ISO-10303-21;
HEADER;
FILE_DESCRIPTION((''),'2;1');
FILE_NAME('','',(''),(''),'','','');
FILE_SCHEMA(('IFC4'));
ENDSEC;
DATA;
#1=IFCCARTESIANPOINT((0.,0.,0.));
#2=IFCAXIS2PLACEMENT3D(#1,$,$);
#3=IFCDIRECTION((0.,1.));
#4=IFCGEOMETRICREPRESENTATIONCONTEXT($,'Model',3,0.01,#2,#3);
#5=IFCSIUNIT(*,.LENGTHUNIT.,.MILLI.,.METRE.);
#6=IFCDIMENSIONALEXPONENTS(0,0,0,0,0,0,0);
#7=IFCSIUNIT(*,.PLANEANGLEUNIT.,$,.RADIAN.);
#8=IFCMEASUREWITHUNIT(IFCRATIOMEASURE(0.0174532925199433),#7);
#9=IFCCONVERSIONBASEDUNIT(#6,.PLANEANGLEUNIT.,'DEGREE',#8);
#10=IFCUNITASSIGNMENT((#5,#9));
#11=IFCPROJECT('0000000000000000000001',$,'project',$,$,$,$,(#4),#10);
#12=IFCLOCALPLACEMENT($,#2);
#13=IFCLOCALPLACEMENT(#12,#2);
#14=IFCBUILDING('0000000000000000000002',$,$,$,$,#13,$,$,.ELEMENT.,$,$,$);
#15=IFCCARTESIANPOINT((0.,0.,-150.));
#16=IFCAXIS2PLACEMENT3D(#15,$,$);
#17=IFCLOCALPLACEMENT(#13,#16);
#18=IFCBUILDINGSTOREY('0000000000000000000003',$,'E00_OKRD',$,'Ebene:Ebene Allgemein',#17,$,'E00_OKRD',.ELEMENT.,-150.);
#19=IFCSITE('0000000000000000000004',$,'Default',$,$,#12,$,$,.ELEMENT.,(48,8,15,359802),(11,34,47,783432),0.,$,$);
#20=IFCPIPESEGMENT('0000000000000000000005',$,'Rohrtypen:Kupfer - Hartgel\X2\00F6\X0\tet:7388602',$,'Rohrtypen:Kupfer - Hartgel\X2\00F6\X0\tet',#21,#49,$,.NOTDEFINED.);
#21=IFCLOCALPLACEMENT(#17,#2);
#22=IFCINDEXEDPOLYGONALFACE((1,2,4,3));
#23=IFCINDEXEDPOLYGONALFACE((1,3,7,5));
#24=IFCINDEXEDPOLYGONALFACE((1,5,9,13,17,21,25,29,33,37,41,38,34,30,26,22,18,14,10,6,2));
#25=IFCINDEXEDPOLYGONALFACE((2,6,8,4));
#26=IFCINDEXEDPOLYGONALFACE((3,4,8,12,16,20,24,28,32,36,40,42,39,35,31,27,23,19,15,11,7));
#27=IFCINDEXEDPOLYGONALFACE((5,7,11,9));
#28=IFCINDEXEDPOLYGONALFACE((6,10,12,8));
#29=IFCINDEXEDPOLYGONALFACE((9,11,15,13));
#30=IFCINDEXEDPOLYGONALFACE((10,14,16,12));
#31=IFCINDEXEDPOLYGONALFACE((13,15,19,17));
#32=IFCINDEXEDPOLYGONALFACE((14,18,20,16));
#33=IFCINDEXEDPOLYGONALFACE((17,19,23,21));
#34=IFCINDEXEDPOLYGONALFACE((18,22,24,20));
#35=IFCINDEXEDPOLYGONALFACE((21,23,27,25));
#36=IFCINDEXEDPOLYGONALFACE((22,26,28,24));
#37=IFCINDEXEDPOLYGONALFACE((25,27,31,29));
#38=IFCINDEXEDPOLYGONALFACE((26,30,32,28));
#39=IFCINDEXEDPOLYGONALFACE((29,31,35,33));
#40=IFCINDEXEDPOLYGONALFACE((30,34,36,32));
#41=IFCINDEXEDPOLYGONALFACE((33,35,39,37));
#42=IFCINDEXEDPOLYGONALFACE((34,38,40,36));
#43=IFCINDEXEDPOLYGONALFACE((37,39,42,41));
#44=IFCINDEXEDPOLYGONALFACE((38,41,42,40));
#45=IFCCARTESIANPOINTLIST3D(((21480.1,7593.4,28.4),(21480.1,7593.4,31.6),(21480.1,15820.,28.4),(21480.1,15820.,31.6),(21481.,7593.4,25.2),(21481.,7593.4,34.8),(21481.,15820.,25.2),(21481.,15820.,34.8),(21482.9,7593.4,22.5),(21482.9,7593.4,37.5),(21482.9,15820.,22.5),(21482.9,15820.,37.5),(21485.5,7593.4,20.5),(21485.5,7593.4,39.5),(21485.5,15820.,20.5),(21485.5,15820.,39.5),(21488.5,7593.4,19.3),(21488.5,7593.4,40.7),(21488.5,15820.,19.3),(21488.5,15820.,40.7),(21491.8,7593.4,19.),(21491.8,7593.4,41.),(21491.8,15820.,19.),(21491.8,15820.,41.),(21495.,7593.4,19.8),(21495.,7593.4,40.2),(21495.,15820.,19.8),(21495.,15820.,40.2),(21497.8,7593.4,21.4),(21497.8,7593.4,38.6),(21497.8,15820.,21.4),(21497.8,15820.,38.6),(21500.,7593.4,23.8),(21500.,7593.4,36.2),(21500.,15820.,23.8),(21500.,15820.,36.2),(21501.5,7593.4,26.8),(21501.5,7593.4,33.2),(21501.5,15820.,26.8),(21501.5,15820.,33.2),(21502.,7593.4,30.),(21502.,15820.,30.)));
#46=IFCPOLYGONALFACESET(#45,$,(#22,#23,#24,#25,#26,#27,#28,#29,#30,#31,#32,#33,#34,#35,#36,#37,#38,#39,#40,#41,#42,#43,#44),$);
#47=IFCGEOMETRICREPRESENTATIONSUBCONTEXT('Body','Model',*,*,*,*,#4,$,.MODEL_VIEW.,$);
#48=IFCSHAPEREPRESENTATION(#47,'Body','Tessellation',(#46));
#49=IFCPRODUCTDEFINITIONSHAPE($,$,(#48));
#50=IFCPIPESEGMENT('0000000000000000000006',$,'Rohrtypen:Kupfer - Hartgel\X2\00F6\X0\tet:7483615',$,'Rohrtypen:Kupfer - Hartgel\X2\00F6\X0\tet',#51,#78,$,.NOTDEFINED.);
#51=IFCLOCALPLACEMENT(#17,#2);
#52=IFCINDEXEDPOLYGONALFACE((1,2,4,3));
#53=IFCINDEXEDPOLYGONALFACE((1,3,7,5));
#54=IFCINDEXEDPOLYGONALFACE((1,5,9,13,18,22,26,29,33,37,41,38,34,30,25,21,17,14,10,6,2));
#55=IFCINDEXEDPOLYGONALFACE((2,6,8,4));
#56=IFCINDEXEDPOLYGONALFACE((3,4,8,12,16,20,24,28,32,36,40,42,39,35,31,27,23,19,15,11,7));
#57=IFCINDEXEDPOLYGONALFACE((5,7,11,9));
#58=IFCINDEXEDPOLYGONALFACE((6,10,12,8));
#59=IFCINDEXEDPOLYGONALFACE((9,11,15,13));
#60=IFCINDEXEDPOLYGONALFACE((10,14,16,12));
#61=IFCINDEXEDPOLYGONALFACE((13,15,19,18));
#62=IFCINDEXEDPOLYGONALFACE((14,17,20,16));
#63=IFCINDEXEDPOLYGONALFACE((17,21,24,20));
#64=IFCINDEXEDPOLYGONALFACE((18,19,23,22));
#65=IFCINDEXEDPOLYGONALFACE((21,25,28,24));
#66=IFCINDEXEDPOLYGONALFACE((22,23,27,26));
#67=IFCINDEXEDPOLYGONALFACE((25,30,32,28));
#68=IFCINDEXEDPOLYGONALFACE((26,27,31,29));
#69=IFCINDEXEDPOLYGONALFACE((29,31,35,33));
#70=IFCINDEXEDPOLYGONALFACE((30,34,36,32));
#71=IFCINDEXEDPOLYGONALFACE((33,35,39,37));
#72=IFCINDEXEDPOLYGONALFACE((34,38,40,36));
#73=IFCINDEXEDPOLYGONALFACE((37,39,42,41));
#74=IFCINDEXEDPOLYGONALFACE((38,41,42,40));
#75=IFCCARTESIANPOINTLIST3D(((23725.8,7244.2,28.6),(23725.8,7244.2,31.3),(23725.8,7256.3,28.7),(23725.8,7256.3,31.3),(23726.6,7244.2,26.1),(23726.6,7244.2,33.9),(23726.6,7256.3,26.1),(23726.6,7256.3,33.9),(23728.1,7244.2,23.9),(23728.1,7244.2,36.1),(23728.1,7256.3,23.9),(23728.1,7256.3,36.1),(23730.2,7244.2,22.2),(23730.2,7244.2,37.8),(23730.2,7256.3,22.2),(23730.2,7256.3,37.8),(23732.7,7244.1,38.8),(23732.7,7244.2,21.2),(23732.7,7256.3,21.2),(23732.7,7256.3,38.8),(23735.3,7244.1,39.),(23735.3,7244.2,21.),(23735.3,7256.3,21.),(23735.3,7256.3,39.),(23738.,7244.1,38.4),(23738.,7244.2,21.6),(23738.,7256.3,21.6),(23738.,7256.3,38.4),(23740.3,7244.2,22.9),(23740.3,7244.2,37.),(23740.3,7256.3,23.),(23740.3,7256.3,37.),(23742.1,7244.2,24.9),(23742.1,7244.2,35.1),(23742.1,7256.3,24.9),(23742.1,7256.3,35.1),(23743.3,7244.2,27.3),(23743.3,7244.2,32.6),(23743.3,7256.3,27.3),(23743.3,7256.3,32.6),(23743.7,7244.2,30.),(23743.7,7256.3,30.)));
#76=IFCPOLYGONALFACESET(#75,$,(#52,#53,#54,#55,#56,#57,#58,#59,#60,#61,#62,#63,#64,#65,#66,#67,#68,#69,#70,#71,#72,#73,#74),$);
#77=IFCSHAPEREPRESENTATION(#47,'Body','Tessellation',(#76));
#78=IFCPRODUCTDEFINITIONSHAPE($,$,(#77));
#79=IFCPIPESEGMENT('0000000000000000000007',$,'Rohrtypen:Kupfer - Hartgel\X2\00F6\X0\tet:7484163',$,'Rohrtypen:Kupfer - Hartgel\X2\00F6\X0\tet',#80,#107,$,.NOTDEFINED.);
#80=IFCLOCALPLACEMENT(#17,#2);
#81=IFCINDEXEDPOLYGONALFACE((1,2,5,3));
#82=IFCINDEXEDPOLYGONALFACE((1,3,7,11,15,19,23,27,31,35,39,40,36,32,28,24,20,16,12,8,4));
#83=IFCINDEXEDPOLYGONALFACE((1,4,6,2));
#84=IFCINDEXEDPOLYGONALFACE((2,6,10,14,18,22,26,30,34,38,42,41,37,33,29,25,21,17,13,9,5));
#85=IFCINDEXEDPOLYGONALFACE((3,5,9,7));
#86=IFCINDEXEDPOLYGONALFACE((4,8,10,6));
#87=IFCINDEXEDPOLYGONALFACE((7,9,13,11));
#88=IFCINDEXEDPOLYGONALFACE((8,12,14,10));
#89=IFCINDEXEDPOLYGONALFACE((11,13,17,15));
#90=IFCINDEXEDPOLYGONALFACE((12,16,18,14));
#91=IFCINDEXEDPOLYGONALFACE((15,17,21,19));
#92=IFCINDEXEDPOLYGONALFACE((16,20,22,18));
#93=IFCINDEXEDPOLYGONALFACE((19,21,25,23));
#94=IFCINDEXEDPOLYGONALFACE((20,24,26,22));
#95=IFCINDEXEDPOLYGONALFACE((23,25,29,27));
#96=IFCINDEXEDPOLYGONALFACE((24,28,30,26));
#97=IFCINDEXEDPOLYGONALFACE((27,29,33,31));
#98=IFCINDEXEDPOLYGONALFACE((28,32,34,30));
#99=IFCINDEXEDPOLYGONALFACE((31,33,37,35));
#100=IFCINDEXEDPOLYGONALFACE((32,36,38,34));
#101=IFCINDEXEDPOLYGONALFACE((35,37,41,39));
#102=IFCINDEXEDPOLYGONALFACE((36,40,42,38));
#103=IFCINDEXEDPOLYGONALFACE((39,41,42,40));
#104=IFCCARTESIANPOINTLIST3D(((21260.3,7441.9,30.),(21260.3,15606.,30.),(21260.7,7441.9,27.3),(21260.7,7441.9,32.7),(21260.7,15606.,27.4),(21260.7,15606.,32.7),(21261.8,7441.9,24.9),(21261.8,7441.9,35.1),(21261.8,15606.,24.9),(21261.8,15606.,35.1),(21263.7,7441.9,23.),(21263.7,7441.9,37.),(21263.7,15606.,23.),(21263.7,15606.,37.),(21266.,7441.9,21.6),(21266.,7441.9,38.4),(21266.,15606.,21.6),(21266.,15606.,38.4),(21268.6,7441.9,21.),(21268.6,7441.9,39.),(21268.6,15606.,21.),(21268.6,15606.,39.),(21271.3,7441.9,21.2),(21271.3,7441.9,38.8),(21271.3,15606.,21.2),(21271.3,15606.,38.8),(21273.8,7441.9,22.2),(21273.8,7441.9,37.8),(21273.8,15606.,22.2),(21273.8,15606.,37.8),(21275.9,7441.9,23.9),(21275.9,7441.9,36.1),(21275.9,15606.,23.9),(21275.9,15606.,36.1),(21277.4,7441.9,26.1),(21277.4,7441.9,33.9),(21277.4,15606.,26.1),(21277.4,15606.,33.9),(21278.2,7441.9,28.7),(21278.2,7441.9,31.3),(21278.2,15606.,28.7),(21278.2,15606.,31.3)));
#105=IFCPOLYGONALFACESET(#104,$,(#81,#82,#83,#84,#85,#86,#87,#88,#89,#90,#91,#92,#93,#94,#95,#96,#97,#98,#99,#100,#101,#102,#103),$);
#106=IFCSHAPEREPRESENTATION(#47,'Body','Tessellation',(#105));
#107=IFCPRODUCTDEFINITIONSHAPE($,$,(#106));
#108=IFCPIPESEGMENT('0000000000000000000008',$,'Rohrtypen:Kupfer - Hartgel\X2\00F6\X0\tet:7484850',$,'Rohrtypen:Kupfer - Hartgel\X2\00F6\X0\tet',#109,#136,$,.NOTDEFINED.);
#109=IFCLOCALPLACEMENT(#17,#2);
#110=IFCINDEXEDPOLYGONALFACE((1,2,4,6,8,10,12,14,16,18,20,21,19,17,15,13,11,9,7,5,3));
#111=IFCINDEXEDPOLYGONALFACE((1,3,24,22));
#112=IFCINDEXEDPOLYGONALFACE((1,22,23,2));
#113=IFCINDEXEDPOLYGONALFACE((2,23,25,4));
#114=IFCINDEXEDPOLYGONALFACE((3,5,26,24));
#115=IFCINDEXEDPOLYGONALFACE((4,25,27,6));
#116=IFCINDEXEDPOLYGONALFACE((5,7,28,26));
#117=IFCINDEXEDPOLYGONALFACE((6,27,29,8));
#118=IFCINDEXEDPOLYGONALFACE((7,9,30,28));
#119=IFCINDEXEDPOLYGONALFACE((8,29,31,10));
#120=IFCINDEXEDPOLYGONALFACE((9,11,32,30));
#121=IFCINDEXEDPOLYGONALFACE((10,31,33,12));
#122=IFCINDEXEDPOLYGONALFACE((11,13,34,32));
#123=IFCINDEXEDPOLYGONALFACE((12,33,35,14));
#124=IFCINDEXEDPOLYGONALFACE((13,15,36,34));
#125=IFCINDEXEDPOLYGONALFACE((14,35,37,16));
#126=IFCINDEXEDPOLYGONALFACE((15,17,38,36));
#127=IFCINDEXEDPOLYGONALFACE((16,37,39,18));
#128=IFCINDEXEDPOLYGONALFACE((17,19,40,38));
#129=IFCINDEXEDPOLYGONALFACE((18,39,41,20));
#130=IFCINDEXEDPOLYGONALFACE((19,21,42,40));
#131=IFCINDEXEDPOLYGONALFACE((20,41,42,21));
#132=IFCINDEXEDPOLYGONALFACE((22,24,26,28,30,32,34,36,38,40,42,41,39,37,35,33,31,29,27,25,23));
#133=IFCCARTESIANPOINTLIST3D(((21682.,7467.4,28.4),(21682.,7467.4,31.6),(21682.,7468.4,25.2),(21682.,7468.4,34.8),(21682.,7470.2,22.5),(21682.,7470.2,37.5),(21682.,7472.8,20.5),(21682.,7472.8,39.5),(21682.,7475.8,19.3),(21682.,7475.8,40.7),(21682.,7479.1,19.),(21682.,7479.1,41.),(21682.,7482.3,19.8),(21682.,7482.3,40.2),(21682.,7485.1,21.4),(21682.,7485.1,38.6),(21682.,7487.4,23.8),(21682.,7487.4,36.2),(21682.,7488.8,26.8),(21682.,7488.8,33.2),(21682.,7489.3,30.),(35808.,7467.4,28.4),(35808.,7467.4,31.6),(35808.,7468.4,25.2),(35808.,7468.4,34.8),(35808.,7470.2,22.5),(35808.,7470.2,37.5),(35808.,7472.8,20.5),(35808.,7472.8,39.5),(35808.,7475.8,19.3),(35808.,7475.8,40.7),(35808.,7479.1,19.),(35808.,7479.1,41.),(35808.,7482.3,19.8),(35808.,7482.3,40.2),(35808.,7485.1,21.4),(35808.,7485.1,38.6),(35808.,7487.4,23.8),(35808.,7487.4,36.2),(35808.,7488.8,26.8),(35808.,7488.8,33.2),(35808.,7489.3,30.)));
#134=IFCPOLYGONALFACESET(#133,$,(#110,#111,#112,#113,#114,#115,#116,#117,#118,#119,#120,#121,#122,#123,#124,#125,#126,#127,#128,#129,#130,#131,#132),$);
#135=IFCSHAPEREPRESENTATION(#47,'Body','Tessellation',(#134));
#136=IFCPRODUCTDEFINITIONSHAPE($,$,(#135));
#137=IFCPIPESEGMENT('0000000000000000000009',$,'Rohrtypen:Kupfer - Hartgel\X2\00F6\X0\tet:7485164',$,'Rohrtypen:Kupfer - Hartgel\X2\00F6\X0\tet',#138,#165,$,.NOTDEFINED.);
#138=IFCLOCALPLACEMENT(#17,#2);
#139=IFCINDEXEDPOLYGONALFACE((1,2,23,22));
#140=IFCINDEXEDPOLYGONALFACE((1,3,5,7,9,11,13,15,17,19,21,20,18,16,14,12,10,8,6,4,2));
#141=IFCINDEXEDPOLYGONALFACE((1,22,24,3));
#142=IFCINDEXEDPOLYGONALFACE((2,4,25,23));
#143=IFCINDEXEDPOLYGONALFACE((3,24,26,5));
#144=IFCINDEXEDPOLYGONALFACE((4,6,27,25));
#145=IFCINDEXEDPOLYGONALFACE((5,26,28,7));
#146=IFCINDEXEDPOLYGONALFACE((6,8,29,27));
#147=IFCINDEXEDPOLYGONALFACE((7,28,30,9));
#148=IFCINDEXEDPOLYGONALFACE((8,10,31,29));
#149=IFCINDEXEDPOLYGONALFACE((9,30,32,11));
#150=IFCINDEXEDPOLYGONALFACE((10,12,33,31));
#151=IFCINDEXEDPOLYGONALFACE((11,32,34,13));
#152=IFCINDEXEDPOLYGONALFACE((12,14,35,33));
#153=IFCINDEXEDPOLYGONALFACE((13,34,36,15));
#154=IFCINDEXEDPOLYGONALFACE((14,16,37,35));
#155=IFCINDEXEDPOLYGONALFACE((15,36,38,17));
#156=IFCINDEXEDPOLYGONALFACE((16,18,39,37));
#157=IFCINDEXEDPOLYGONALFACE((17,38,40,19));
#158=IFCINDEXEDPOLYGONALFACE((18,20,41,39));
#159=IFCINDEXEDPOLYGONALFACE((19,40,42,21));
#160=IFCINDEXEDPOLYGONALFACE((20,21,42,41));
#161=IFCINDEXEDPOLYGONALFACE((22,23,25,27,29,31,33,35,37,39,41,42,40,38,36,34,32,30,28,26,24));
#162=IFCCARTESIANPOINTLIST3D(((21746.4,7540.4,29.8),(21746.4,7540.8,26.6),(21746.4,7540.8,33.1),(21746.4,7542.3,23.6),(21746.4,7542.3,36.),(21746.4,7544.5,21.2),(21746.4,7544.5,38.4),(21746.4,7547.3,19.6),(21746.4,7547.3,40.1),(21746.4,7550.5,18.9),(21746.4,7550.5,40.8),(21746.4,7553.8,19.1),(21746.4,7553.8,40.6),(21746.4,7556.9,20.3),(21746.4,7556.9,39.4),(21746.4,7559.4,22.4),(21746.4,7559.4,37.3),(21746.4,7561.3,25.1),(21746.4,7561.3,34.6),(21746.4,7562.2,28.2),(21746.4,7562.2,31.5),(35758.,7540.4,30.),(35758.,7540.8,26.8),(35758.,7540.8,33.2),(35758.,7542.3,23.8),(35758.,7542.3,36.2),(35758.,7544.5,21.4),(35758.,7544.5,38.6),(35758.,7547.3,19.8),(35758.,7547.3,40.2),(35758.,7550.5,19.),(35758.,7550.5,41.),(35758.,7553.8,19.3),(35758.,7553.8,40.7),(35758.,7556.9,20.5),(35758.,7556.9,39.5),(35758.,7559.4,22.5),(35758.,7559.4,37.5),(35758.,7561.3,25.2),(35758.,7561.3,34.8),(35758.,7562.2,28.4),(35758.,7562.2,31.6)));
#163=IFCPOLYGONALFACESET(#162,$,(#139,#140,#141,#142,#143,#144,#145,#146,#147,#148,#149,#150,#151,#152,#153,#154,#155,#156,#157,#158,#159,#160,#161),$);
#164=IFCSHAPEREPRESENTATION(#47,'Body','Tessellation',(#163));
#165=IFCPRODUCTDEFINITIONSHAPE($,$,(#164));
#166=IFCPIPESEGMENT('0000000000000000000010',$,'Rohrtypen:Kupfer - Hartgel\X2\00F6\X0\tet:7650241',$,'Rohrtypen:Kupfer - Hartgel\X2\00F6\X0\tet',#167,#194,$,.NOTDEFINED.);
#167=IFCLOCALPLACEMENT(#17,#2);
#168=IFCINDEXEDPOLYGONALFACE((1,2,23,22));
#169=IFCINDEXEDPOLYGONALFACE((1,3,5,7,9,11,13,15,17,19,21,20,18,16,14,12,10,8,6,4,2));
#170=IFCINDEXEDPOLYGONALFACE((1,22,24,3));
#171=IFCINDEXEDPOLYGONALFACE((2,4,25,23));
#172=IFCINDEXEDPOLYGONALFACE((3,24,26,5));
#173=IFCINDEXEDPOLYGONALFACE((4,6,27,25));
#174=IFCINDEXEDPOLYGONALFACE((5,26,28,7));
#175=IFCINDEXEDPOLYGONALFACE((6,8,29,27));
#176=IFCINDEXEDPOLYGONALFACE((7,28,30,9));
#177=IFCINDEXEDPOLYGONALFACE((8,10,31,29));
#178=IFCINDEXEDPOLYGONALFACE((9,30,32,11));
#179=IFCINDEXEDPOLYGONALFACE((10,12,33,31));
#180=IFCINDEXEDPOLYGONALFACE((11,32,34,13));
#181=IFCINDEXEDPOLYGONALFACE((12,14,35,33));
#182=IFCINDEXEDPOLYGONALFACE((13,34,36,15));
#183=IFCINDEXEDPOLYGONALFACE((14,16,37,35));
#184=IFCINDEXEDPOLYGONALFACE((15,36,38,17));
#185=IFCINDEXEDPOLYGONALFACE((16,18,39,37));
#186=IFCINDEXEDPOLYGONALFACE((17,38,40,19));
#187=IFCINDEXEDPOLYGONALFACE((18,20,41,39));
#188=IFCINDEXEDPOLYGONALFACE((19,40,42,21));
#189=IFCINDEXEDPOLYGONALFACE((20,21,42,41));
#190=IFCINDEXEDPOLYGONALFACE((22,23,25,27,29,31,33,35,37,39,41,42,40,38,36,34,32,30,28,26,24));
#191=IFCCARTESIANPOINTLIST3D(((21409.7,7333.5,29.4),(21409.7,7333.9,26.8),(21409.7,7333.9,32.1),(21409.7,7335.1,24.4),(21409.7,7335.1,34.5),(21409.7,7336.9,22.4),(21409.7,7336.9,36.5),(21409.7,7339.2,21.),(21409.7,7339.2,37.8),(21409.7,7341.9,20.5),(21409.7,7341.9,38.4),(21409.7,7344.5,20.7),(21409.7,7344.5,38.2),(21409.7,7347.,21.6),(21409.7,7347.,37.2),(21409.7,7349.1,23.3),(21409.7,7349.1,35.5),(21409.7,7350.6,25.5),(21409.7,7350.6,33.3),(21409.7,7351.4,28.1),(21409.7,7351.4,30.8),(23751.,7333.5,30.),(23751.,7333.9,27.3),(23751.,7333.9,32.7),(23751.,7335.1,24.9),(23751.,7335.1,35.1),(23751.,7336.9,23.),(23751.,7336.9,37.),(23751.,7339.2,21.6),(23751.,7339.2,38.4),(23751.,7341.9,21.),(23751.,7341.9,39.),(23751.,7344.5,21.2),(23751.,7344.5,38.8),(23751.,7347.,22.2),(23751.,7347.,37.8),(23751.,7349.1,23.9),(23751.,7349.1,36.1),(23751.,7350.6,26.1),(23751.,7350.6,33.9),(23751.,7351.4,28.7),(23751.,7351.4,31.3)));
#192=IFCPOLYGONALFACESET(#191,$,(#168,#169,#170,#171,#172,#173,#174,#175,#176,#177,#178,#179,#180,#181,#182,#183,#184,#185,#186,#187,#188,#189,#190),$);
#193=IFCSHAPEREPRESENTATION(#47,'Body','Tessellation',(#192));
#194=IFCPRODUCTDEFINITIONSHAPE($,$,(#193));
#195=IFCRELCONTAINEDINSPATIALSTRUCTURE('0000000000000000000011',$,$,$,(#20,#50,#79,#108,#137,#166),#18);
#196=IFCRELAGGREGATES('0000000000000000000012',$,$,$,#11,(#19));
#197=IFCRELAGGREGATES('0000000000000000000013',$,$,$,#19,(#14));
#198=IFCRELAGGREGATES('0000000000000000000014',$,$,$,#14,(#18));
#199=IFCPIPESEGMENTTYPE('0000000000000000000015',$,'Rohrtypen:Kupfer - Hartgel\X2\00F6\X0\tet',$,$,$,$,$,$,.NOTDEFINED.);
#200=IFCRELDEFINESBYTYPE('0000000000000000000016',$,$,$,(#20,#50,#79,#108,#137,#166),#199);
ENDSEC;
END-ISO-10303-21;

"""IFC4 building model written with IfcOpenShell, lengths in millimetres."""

from ifc_helpers import new_model, entity, si_unit, converted_unit, direction, frame, frame_2d, origin, origin_2d_with_axis, place, context, subcontext, project, spatial, circle, extrude, type_object, element, save


model = new_model("IFC4")

# Units and contexts
model_context = context("Model", 3, precision=0.01, world=origin(), true_north=direction((0.0, 1.0)))
body_context = subcontext(model_context, "Body", "Model", "MODEL_VIEW")
ifc_project = project(units=[si_unit("LENGTHUNIT", "METRE", prefix="MILLI"), converted_unit("PLANEANGLEUNIT", "DEGREE", entity("IfcRatioMeasure", 0.0174532925199433), si_unit("PLANEANGLEUNIT", "RADIAN"), dimensions=[0, 0, 0, 0, 0, 0, 0])], contexts=[model_context])

# Site, building, storey
site_placement = place(None, origin())
site = spatial("IfcSite", under=ifc_project, at=site_placement, Name="Default", CompositionType="ELEMENT", RefLatitude=(48, 8, 15, 359802), RefLongitude=(11, 34, 47, 783432), RefElevation=0.0)
building_placement = place(site_placement, origin())
building = spatial("IfcBuilding", under=site, at=building_placement, CompositionType="ELEMENT")
storey_placement = place(building_placement, frame((0.0, 0.0, -150.0)))
storey = spatial("IfcBuildingStorey", under=building, at=storey_placement, Name="E00_OKRD", ObjectType="Ebene:Ebene Allgemein", LongName="E00_OKRD", CompositionType="ELEMENT", Elevation=-150.0)

# Pipe segments
pipe_segment_type = type_object("IfcPipeSegmentType", Name="Rohrtypen:Kupfer - Hartgelötet", PredefinedType="NOTDEFINED")
pipe_segment_1_placement = place(storey_placement, frame((21478.4, 7593.4, 17.4)))
element("IfcPipeSegment", 1, at=pipe_segment_1_placement, inside=storey, type_object=pipe_segment_type, Name="Rohrtypen:Kupfer - Hartgelötet:7388602", ObjectType="Rohrtypen:Kupfer - Hartgelötet", PredefinedType="NOTDEFINED", context=body_context, shape_type="SweptSolid", body=[
    extrude(circle(Radius=11.0, at=frame_2d((0.0, 0.0), x_axis=(1.0, 0.0))), frame((12.6, 0.0, 12.6), z_axis=(0.0, 1.0, 0.0), x_axis=(1.0, 0.0, 0.0)), (0.0, 0.0, 1.0), 8226.7),
])
pipe_segment_2_placement = place(storey_placement, frame((23724.1, 7244.1, 19.4)))
element("IfcPipeSegment", 2, at=pipe_segment_2_placement, inside=storey, type_object=pipe_segment_type, Name="Rohrtypen:Kupfer - Hartgelötet:7483615", ObjectType="Rohrtypen:Kupfer - Hartgelötet", PredefinedType="NOTDEFINED", context=body_context, shape_type="SweptSolid", body=[
    extrude(circle(Radius=9.0, at=frame_2d((0.0, 0.0), x_axis=(1.0, 0.0))), frame((10.6, 0.0, 10.6), z_axis=(0.0, 1.0, 0.000964), x_axis=(1.0, 0.0, 0.0)), (0.0, 0.0, 1.0), 12.1),
])
pipe_segment_3_placement = place(storey_placement, frame((21258.7, 7441.9, 19.4)))
element("IfcPipeSegment", 3, at=pipe_segment_3_placement, inside=storey, type_object=pipe_segment_type, Name="Rohrtypen:Kupfer - Hartgelötet:7484163", ObjectType="Rohrtypen:Kupfer - Hartgelötet", PredefinedType="NOTDEFINED", context=body_context, shape_type="SweptSolid", body=[
    extrude(circle(Radius=9.0, at=origin_2d_with_axis()), frame((10.6, 0.0, 10.6), z_axis=(0.0, 1.0, 0.000001), x_axis=(-1.0, 0.0, 0.0)), (0.0, 0.0, 1.0), 8164.0),
])
pipe_segment_4_placement = place(storey_placement, frame((21682.0, 7465.7, 17.4)))
element("IfcPipeSegment", 4, at=pipe_segment_4_placement, inside=storey, type_object=pipe_segment_type, Name="Rohrtypen:Kupfer - Hartgelötet:7484850", ObjectType="Rohrtypen:Kupfer - Hartgelötet", PredefinedType="NOTDEFINED", context=body_context, shape_type="SweptSolid", body=[
    extrude(circle(Radius=11.0, at=frame_2d((0.0, 0.0), x_axis=(1.0, 0.0))), frame((0.0, 12.6, 12.6), z_axis=(1.0, 0.0, 0.0), x_axis=(0.0, 1.0, 0.0)), (0.0, 0.0, 1.0), 14126.0),
])
pipe_segment_5_placement = place(storey_placement, frame((21746.4, 7538.8, 17.2)))
element("IfcPipeSegment", 5, at=pipe_segment_5_placement, inside=storey, type_object=pipe_segment_type, Name="Rohrtypen:Kupfer - Hartgelötet:7485164", ObjectType="Rohrtypen:Kupfer - Hartgelötet", PredefinedType="NOTDEFINED", context=body_context, shape_type="SweptSolid", body=[
    extrude(circle(Radius=11.0, at=frame_2d((0.0, 0.0), x_axis=(1.0, 0.0))), frame((0.0, 12.6, 12.6), z_axis=(1.0, 0.0, 0.000012), x_axis=(0.0, -1.0, 0.0)), (0.0, 0.0, 1.0), 14011.5),
])
pipe_segment_6_placement = place(storey_placement, frame((21409.7, 7331.9, 18.8)))
element("IfcPipeSegment", 6, at=pipe_segment_6_placement, inside=storey, type_object=pipe_segment_type, Name="Rohrtypen:Kupfer - Hartgelötet:7650241", ObjectType="Rohrtypen:Kupfer - Hartgelötet", PredefinedType="NOTDEFINED", context=body_context, shape_type="SweptSolid", body=[
    extrude(circle(Radius=9.0, at=frame_2d((0.0, 0.0), x_axis=(1.0, 0.0))), frame((0.0, 10.6, 10.6), z_axis=(1.0, 0.0, 0.000244), x_axis=(0.0, -1.0, 0.0)), (0.0, 0.0, 1.0), 2341.3),
])

save(model, "model.ifc")
